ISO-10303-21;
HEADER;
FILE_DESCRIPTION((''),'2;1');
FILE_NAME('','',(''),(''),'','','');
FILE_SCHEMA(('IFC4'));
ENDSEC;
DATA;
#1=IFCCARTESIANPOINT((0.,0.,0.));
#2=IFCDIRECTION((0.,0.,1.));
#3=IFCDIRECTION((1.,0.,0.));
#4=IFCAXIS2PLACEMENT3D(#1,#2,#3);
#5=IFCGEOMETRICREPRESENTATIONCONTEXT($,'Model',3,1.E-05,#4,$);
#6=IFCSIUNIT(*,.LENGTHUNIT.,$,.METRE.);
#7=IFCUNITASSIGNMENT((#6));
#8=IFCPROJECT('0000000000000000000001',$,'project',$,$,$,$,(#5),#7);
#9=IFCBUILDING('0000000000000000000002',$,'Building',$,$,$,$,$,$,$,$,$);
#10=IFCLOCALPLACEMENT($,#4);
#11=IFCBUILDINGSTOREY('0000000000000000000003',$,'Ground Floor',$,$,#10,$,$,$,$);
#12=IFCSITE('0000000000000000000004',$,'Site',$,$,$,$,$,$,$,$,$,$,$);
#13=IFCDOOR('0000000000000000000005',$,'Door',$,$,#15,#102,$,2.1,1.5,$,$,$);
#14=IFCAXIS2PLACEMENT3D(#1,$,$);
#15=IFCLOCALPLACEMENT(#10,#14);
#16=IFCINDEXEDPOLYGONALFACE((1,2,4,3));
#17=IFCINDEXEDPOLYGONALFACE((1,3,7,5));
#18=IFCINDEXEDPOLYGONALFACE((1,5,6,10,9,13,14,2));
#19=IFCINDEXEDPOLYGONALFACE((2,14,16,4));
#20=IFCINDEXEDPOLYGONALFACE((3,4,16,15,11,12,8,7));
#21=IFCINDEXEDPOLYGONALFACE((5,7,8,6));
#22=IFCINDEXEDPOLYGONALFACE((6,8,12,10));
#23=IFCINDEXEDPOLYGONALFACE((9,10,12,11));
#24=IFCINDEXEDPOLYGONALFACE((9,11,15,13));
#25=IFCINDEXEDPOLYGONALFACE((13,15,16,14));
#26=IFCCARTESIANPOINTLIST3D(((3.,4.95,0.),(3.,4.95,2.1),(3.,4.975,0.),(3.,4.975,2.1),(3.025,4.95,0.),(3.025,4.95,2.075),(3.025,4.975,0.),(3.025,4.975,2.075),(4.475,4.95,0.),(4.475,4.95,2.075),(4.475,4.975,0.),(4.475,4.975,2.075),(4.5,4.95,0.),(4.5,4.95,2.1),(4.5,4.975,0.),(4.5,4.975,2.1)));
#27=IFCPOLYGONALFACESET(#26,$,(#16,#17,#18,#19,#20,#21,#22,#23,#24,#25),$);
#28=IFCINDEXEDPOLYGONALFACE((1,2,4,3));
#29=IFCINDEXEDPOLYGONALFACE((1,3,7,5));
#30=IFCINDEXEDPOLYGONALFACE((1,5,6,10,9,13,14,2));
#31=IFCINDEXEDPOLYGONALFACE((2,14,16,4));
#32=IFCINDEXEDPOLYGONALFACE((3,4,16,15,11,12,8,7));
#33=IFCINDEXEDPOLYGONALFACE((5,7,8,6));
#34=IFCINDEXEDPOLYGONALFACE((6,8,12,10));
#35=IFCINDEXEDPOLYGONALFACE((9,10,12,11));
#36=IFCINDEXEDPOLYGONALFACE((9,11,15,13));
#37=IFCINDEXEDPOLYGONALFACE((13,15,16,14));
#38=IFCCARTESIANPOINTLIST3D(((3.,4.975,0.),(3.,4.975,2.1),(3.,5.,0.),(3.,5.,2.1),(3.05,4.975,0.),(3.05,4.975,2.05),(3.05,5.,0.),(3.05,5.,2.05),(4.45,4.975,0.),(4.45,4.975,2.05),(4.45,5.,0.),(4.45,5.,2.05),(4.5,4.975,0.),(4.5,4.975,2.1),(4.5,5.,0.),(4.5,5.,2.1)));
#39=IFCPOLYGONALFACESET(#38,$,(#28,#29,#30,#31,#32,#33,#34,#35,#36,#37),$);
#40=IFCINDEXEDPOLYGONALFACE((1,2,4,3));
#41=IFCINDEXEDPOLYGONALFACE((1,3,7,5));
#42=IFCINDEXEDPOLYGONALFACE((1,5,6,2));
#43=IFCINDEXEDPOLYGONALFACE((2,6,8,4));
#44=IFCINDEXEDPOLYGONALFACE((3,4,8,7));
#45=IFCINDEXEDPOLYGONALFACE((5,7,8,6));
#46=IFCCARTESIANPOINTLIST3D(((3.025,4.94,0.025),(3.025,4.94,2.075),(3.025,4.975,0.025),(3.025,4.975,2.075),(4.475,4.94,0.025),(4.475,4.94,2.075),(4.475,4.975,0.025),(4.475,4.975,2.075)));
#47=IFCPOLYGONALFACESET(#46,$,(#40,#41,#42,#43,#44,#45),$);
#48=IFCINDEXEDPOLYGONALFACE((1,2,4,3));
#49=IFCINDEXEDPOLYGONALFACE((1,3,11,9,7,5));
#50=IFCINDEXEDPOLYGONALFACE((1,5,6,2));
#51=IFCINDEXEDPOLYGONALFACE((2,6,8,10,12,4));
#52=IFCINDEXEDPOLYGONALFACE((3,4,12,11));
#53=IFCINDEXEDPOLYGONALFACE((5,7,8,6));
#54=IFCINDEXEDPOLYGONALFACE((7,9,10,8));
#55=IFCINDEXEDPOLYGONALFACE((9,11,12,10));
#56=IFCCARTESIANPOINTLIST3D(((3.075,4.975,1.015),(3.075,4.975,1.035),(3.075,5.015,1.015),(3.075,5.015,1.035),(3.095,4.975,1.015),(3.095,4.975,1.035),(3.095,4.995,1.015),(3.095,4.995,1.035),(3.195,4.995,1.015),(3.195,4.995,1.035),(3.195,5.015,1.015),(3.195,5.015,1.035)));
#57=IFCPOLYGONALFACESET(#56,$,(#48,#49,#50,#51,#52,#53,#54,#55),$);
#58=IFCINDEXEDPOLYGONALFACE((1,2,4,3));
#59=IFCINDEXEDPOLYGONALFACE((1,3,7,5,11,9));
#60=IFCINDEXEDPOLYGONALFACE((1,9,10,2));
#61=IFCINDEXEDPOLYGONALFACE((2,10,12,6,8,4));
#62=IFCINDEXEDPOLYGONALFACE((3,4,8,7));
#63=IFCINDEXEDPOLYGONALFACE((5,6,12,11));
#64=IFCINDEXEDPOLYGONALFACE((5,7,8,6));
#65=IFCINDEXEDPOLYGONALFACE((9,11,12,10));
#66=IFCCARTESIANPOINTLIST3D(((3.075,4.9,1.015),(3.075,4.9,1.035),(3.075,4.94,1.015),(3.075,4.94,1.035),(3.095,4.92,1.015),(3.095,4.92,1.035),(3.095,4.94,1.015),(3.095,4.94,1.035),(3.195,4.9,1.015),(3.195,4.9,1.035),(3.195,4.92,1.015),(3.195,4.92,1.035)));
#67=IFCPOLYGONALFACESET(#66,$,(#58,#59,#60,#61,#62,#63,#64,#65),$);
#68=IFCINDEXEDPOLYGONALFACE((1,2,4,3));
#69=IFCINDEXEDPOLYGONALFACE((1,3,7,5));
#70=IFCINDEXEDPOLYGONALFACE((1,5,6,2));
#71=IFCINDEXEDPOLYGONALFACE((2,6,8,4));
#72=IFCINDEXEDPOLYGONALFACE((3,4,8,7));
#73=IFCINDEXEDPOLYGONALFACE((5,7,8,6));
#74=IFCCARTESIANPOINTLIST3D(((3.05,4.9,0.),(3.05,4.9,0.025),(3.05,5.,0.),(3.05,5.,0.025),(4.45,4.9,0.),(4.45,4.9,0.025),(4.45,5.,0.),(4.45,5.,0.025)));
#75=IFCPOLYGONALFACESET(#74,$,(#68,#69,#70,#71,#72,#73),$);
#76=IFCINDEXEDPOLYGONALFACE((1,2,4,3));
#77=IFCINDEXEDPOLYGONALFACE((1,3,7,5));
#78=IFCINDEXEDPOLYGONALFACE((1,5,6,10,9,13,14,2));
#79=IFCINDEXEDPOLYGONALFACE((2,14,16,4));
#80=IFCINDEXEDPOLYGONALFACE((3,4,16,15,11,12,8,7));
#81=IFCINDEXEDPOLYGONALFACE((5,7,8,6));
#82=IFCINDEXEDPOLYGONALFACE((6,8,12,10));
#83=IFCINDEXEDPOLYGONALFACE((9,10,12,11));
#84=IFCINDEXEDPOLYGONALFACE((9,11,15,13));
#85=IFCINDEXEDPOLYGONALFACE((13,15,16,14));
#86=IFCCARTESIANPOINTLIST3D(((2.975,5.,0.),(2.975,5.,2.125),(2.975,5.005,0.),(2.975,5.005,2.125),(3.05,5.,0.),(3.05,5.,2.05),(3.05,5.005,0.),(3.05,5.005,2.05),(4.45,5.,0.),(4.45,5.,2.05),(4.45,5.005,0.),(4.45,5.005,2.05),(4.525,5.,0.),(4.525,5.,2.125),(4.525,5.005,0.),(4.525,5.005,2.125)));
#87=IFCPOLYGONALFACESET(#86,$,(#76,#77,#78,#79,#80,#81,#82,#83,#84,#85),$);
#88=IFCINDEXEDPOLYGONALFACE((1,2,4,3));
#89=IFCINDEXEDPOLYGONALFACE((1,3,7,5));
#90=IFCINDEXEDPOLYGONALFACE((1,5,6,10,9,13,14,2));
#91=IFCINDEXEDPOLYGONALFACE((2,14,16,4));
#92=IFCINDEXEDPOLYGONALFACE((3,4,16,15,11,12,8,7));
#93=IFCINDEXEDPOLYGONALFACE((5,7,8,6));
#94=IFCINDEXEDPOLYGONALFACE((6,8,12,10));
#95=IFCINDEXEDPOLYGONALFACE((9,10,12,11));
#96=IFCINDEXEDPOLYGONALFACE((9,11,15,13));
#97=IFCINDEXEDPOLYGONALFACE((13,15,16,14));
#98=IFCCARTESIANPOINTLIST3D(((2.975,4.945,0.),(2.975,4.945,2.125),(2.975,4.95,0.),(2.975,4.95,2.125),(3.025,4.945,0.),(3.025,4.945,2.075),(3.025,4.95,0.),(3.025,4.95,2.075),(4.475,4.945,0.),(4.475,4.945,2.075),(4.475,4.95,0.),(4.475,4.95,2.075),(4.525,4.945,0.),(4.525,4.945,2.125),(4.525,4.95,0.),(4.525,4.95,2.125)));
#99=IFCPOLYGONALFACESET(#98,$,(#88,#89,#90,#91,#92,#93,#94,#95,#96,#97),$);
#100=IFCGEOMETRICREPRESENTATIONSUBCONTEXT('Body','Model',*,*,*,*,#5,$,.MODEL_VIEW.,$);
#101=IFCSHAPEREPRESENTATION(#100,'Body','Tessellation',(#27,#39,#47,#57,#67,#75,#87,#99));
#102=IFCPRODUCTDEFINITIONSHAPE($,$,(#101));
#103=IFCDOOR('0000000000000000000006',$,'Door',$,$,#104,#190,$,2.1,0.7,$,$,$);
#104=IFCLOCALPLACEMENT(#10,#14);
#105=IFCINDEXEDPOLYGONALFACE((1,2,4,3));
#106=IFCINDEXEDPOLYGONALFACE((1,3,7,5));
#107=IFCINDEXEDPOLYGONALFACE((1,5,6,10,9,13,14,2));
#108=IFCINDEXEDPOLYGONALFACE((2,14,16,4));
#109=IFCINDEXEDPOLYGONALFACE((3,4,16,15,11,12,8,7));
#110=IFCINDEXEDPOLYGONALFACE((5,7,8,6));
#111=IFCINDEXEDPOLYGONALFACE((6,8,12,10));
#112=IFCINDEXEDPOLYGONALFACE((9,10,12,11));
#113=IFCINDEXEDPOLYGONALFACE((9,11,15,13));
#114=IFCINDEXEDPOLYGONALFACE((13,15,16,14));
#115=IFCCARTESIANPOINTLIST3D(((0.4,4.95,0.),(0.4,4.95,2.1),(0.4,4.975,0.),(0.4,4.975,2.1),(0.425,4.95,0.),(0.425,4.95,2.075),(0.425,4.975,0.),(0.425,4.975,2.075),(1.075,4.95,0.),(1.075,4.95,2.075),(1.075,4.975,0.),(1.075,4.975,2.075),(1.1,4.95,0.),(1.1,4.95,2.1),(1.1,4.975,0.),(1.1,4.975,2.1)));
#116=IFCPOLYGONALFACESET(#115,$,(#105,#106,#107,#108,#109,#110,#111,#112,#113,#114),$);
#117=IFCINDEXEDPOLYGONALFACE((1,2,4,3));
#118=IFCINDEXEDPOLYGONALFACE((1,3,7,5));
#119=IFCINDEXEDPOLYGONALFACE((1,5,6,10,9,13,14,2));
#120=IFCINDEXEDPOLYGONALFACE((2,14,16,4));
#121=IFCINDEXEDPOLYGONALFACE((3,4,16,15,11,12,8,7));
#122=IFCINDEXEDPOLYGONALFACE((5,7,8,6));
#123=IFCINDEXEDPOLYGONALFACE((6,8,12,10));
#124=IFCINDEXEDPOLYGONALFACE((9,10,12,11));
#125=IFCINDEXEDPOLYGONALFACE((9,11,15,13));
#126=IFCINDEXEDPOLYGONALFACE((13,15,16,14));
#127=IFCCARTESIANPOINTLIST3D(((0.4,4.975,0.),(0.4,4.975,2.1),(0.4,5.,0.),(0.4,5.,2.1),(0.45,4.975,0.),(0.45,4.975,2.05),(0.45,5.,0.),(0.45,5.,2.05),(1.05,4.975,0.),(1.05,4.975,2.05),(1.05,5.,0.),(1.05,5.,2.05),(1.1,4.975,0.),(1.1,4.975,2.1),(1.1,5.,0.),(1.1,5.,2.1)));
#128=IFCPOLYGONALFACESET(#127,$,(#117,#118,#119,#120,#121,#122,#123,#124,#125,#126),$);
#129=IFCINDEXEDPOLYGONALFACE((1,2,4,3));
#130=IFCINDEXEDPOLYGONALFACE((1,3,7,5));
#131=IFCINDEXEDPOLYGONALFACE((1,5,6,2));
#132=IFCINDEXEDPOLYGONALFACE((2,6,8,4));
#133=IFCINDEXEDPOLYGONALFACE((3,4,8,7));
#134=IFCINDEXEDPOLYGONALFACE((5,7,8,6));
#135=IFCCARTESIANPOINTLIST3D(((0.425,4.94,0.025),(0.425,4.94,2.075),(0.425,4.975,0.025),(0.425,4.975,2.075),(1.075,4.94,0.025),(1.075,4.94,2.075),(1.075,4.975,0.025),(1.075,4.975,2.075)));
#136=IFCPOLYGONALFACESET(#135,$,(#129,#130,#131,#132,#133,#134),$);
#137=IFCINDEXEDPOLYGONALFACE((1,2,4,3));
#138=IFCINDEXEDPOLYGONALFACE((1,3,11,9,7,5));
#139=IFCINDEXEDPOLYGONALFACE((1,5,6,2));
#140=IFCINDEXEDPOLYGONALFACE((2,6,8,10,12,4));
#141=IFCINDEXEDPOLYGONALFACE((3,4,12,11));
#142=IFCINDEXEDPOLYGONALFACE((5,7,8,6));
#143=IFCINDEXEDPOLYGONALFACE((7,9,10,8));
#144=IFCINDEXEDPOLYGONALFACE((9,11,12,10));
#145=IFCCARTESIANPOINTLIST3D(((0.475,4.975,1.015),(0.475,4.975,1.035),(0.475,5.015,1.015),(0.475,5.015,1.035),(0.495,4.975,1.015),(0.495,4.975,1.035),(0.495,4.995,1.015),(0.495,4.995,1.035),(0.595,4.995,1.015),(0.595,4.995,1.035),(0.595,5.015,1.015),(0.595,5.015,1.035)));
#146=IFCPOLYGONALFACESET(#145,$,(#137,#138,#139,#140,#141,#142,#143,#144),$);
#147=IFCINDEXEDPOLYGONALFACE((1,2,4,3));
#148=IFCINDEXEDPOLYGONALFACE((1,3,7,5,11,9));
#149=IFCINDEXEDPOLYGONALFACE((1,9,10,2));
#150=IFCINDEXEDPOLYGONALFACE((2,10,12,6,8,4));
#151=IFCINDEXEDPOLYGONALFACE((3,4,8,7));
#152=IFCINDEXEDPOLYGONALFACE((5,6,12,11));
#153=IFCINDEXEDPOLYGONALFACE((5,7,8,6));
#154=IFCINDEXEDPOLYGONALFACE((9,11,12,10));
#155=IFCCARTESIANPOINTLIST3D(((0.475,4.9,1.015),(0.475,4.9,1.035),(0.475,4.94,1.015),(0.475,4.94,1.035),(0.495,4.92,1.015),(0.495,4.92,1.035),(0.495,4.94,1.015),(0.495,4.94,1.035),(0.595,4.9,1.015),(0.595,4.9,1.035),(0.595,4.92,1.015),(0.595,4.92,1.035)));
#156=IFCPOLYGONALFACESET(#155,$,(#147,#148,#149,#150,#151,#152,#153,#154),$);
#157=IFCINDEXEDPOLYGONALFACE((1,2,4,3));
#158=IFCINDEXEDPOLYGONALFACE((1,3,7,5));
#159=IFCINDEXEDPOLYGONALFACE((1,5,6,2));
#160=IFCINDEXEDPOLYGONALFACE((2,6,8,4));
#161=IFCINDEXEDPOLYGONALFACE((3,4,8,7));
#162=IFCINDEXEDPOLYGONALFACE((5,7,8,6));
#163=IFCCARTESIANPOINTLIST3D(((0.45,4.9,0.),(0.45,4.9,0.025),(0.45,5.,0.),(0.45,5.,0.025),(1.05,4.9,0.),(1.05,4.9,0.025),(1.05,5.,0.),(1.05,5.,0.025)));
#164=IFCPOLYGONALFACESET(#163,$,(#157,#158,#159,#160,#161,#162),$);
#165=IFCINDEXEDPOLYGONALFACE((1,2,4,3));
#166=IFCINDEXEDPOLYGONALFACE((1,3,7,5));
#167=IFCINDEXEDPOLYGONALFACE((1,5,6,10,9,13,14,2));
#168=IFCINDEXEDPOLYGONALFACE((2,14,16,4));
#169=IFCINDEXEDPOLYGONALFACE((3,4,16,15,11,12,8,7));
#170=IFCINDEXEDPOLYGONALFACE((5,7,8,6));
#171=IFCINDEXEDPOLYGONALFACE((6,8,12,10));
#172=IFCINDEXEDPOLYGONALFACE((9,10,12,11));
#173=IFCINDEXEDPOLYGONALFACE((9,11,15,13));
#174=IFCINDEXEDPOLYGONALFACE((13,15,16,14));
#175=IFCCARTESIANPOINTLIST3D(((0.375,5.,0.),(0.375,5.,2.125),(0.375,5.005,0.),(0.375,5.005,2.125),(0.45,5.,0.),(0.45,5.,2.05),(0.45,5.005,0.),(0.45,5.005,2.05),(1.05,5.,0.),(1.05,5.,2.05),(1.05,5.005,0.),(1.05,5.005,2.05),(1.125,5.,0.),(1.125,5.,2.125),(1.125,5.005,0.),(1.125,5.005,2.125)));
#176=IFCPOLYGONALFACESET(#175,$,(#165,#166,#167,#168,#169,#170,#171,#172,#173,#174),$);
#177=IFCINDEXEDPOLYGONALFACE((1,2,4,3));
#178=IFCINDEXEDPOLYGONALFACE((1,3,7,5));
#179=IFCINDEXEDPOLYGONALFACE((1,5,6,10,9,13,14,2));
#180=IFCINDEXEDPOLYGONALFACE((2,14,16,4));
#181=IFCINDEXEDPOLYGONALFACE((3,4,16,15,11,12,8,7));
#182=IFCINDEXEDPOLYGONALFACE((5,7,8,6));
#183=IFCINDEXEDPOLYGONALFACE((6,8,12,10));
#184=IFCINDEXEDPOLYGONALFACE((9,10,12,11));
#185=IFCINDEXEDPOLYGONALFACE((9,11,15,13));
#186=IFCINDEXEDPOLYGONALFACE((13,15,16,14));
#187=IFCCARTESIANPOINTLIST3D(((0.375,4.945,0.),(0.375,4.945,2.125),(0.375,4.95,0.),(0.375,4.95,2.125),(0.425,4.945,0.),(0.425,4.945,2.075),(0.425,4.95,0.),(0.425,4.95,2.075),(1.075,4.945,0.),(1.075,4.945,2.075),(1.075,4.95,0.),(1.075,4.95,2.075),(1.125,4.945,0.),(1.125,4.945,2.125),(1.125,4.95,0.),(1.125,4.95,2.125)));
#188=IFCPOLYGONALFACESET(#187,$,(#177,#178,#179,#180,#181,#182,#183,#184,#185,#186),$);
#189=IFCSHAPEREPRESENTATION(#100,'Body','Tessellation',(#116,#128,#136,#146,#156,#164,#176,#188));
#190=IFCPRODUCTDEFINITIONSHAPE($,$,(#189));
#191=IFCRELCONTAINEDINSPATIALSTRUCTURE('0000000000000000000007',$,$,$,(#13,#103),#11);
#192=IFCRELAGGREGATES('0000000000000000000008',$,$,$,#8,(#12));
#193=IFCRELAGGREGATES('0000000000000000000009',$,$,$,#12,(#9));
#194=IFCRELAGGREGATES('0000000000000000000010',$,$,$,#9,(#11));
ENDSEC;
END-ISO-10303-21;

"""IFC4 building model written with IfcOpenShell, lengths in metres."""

from ifc_helpers import new_model, si_unit, frame, origin_with_axes, place, context, subcontext, project, spatial, line, indexed_curve, outline, extrude, element, save


model = new_model("IFC4")

# Units and contexts
model_context = context("Model", 3, precision=1e-05, world=origin_with_axes())
body_context = subcontext(model_context, "Body", "Model", "MODEL_VIEW")
ifc_project = project(units=[si_unit("LENGTHUNIT", "METRE")], contexts=[model_context])

# Site, building, storey
site = spatial("IfcSite", under=ifc_project, Name="Site")
building = spatial("IfcBuilding", under=site, Name="Building")
storey_placement = place(None, origin_with_axes())
storey = spatial("IfcBuildingStorey", under=building, at=storey_placement, Name="Ground Floor")

# Doors
door_1_placement = place(storey_placement, frame((4.5, 5.0, 0.0), z_axis=(0.0, 0.0, 1.0), x_axis=(-1.0, 0.0, 0.0)))
element("IfcDoor", 1, at=door_1_placement, inside=storey, Name="Door", OverallHeight=2.1, OverallWidth=1.5, context=body_context, shape_type="SweptSolid", body=[
    extrude(outline(indexed_curve([(0.0, 0.0), (0.0, 2.1), (1.5, 2.1), (1.5, 0.0), (1.475, 0.0), (1.475, 2.075), (0.025, 2.075), (0.025, 0.0)], segments=[line(1, 2, 3, 4, 5, 6, 7, 8, 1)])), frame((0.0, 0.025, 0.0), z_axis=(0.0, -1.0, 0.0), x_axis=(1.0, 0.0, 0.0)), (0.0, 0.0, -1.0), 0.025),
    extrude(outline(indexed_curve([(0.0, 0.0), (0.0, 2.1), (1.5, 2.1), (1.5, 0.0), (1.45, 0.0), (1.45, 2.05), (0.05, 2.05), (0.05, 0.0)], segments=[line(1, 2, 3, 4, 5, 6, 7, 8, 1)])), frame((0.0, 0.0, 0.0), z_axis=(0.0, -1.0, 0.0), x_axis=(1.0, 0.0, 0.0)), (0.0, 0.0, -1.0), 0.025),
    extrude(outline(indexed_curve([(0.0, 0.0), (1.45, 0.0), (1.45, 0.035), (0.0, 0.035)], segments=[line(1, 2, 3, 4, 1)])), frame((0.025, 0.025, 0.025), z_axis=(0.0, 0.0, 1.0), x_axis=(1.0, 0.0, 0.0)), (0.0, 0.0, 1.0), 2.05),
    extrude(outline(indexed_curve([(0.0, 0.0), (0.0, -0.04), (-0.12, -0.04), (-0.12, -0.02), (-0.02, -0.02), (-0.02, 0.0)], segments=[line(1, 2, 3, 4, 5, 6, 1)])), frame((1.425, 0.025, 1.015), z_axis=(0.0, 0.0, 1.0), x_axis=(1.0, 0.0, 0.0)), (0.0, 0.0, 1.0), 0.02),
    extrude(outline(indexed_curve([(0.0, 0.0), (0.0, 0.04), (-0.12, 0.04), (-0.12, 0.02), (-0.02, 0.02), (-0.02, 0.0)], segments=[line(1, 2, 3, 4, 5, 6, 1)])), frame((1.425, 0.06, 1.015), z_axis=(0.0, 0.0, 1.0), x_axis=(1.0, 0.0, 0.0)), (0.0, 0.0, 1.0), 0.02),
    extrude(outline(indexed_curve([(0.0, 0.0), (1.4, 0.0), (1.4, 0.1), (0.0, 0.1)], segments=[line(1, 2, 3, 4, 1)])), frame((0.05, 0.0, 0.0), z_axis=(0.0, 0.0, 1.0), x_axis=(1.0, 0.0, 0.0)), (0.0, 0.0, 1.0), 0.025),
    extrude(outline(indexed_curve([(0.0, 0.0), (0.0, 2.125), (1.55, 2.125), (1.55, 0.0), (1.475, 0.0), (1.475, 2.05), (0.075, 2.05), (0.075, 0.0)], segments=[line(1, 2, 3, 4, 5, 6, 7, 8, 1)])), frame((-0.025, -0.005, 0.0), z_axis=(0.0, -1.0, 0.0), x_axis=(1.0, 0.0, 0.0)), (0.0, 0.0, -1.0), 0.005),
    extrude(outline(indexed_curve([(0.0, 0.0), (0.0, 2.125), (1.55, 2.125), (1.55, 0.0), (1.5, 0.0), (1.5, 2.075), (0.05, 2.075), (0.05, 0.0)], segments=[line(1, 2, 3, 4, 5, 6, 7, 8, 1)])), frame((-0.025, 0.05, 0.0), z_axis=(0.0, -1.0, 0.0), x_axis=(1.0, 0.0, 0.0)), (0.0, 0.0, -1.0), 0.005),
])
door_2_placement = place(storey_placement, frame((1.1, 5.0, 0.0), z_axis=(0.0, 0.0, 1.0), x_axis=(-1.0, 0.0, 0.0)))
element("IfcDoor", 2, at=door_2_placement, inside=storey, Name="Door", OverallHeight=2.1, OverallWidth=0.7, context=body_context, shape_type="SweptSolid", body=[
    extrude(outline(indexed_curve([(0.0, 0.0), (0.0, 2.1), (0.7, 2.1), (0.7, 0.0), (0.675, 0.0), (0.675, 2.075), (0.025, 2.075), (0.025, 0.0)], segments=[line(1, 2, 3, 4, 5, 6, 7, 8, 1)])), frame((0.0, 0.025, 0.0), z_axis=(0.0, -1.0, 0.0), x_axis=(1.0, 0.0, 0.0)), (0.0, 0.0, -1.0), 0.025),
    extrude(outline(indexed_curve([(0.0, 0.0), (0.0, 2.1), (0.7, 2.1), (0.7, 0.0), (0.65, 0.0), (0.65, 2.05), (0.05, 2.05), (0.05, 0.0)], segments=[line(1, 2, 3, 4, 5, 6, 7, 8, 1)])), frame((0.0, 0.0, 0.0), z_axis=(0.0, -1.0, 0.0), x_axis=(1.0, 0.0, 0.0)), (0.0, 0.0, -1.0), 0.025),
    extrude(outline(indexed_curve([(0.0, 0.0), (0.65, 0.0), (0.65, 0.035), (0.0, 0.035)], segments=[line(1, 2, 3, 4, 1)])), frame((0.025, 0.025, 0.025), z_axis=(0.0, 0.0, 1.0), x_axis=(1.0, 0.0, 0.0)), (0.0, 0.0, 1.0), 2.05),
    extrude(outline(indexed_curve([(0.0, 0.0), (0.0, -0.04), (-0.12, -0.04), (-0.12, -0.02), (-0.02, -0.02), (-0.02, 0.0)], segments=[line(1, 2, 3, 4, 5, 6, 1)])), frame((0.625, 0.025, 1.015), z_axis=(0.0, 0.0, 1.0), x_axis=(1.0, 0.0, 0.0)), (0.0, 0.0, 1.0), 0.02),
    extrude(outline(indexed_curve([(0.0, 0.0), (0.0, 0.04), (-0.12, 0.04), (-0.12, 0.02), (-0.02, 0.02), (-0.02, 0.0)], segments=[line(1, 2, 3, 4, 5, 6, 1)])), frame((0.625, 0.06, 1.015), z_axis=(0.0, 0.0, 1.0), x_axis=(1.0, 0.0, 0.0)), (0.0, 0.0, 1.0), 0.02),
    extrude(outline(indexed_curve([(0.0, 0.0), (0.6, 0.0), (0.6, 0.1), (0.0, 0.1)], segments=[line(1, 2, 3, 4, 1)])), frame((0.05, 0.0, 0.0), z_axis=(0.0, 0.0, 1.0), x_axis=(1.0, 0.0, 0.0)), (0.0, 0.0, 1.0), 0.025),
    extrude(outline(indexed_curve([(0.0, 0.0), (0.0, 2.125), (0.75, 2.125), (0.75, 0.0), (0.675, 0.0), (0.675, 2.05), (0.075, 2.05), (0.075, 0.0)], segments=[line(1, 2, 3, 4, 5, 6, 7, 8, 1)])), frame((-0.025, -0.005, 0.0), z_axis=(0.0, -1.0, 0.0), x_axis=(1.0, 0.0, 0.0)), (0.0, 0.0, -1.0), 0.005),
    extrude(outline(indexed_curve([(0.0, 0.0), (0.0, 2.125), (0.75, 2.125), (0.75, 0.0), (0.7, 0.0), (0.7, 2.075), (0.05, 2.075), (0.05, 0.0)], segments=[line(1, 2, 3, 4, 5, 6, 7, 8, 1)])), frame((-0.025, 0.05, 0.0), z_axis=(0.0, -1.0, 0.0), x_axis=(1.0, 0.0, 0.0)), (0.0, 0.0, -1.0), 0.005),
])

save(model, "model.ifc")
